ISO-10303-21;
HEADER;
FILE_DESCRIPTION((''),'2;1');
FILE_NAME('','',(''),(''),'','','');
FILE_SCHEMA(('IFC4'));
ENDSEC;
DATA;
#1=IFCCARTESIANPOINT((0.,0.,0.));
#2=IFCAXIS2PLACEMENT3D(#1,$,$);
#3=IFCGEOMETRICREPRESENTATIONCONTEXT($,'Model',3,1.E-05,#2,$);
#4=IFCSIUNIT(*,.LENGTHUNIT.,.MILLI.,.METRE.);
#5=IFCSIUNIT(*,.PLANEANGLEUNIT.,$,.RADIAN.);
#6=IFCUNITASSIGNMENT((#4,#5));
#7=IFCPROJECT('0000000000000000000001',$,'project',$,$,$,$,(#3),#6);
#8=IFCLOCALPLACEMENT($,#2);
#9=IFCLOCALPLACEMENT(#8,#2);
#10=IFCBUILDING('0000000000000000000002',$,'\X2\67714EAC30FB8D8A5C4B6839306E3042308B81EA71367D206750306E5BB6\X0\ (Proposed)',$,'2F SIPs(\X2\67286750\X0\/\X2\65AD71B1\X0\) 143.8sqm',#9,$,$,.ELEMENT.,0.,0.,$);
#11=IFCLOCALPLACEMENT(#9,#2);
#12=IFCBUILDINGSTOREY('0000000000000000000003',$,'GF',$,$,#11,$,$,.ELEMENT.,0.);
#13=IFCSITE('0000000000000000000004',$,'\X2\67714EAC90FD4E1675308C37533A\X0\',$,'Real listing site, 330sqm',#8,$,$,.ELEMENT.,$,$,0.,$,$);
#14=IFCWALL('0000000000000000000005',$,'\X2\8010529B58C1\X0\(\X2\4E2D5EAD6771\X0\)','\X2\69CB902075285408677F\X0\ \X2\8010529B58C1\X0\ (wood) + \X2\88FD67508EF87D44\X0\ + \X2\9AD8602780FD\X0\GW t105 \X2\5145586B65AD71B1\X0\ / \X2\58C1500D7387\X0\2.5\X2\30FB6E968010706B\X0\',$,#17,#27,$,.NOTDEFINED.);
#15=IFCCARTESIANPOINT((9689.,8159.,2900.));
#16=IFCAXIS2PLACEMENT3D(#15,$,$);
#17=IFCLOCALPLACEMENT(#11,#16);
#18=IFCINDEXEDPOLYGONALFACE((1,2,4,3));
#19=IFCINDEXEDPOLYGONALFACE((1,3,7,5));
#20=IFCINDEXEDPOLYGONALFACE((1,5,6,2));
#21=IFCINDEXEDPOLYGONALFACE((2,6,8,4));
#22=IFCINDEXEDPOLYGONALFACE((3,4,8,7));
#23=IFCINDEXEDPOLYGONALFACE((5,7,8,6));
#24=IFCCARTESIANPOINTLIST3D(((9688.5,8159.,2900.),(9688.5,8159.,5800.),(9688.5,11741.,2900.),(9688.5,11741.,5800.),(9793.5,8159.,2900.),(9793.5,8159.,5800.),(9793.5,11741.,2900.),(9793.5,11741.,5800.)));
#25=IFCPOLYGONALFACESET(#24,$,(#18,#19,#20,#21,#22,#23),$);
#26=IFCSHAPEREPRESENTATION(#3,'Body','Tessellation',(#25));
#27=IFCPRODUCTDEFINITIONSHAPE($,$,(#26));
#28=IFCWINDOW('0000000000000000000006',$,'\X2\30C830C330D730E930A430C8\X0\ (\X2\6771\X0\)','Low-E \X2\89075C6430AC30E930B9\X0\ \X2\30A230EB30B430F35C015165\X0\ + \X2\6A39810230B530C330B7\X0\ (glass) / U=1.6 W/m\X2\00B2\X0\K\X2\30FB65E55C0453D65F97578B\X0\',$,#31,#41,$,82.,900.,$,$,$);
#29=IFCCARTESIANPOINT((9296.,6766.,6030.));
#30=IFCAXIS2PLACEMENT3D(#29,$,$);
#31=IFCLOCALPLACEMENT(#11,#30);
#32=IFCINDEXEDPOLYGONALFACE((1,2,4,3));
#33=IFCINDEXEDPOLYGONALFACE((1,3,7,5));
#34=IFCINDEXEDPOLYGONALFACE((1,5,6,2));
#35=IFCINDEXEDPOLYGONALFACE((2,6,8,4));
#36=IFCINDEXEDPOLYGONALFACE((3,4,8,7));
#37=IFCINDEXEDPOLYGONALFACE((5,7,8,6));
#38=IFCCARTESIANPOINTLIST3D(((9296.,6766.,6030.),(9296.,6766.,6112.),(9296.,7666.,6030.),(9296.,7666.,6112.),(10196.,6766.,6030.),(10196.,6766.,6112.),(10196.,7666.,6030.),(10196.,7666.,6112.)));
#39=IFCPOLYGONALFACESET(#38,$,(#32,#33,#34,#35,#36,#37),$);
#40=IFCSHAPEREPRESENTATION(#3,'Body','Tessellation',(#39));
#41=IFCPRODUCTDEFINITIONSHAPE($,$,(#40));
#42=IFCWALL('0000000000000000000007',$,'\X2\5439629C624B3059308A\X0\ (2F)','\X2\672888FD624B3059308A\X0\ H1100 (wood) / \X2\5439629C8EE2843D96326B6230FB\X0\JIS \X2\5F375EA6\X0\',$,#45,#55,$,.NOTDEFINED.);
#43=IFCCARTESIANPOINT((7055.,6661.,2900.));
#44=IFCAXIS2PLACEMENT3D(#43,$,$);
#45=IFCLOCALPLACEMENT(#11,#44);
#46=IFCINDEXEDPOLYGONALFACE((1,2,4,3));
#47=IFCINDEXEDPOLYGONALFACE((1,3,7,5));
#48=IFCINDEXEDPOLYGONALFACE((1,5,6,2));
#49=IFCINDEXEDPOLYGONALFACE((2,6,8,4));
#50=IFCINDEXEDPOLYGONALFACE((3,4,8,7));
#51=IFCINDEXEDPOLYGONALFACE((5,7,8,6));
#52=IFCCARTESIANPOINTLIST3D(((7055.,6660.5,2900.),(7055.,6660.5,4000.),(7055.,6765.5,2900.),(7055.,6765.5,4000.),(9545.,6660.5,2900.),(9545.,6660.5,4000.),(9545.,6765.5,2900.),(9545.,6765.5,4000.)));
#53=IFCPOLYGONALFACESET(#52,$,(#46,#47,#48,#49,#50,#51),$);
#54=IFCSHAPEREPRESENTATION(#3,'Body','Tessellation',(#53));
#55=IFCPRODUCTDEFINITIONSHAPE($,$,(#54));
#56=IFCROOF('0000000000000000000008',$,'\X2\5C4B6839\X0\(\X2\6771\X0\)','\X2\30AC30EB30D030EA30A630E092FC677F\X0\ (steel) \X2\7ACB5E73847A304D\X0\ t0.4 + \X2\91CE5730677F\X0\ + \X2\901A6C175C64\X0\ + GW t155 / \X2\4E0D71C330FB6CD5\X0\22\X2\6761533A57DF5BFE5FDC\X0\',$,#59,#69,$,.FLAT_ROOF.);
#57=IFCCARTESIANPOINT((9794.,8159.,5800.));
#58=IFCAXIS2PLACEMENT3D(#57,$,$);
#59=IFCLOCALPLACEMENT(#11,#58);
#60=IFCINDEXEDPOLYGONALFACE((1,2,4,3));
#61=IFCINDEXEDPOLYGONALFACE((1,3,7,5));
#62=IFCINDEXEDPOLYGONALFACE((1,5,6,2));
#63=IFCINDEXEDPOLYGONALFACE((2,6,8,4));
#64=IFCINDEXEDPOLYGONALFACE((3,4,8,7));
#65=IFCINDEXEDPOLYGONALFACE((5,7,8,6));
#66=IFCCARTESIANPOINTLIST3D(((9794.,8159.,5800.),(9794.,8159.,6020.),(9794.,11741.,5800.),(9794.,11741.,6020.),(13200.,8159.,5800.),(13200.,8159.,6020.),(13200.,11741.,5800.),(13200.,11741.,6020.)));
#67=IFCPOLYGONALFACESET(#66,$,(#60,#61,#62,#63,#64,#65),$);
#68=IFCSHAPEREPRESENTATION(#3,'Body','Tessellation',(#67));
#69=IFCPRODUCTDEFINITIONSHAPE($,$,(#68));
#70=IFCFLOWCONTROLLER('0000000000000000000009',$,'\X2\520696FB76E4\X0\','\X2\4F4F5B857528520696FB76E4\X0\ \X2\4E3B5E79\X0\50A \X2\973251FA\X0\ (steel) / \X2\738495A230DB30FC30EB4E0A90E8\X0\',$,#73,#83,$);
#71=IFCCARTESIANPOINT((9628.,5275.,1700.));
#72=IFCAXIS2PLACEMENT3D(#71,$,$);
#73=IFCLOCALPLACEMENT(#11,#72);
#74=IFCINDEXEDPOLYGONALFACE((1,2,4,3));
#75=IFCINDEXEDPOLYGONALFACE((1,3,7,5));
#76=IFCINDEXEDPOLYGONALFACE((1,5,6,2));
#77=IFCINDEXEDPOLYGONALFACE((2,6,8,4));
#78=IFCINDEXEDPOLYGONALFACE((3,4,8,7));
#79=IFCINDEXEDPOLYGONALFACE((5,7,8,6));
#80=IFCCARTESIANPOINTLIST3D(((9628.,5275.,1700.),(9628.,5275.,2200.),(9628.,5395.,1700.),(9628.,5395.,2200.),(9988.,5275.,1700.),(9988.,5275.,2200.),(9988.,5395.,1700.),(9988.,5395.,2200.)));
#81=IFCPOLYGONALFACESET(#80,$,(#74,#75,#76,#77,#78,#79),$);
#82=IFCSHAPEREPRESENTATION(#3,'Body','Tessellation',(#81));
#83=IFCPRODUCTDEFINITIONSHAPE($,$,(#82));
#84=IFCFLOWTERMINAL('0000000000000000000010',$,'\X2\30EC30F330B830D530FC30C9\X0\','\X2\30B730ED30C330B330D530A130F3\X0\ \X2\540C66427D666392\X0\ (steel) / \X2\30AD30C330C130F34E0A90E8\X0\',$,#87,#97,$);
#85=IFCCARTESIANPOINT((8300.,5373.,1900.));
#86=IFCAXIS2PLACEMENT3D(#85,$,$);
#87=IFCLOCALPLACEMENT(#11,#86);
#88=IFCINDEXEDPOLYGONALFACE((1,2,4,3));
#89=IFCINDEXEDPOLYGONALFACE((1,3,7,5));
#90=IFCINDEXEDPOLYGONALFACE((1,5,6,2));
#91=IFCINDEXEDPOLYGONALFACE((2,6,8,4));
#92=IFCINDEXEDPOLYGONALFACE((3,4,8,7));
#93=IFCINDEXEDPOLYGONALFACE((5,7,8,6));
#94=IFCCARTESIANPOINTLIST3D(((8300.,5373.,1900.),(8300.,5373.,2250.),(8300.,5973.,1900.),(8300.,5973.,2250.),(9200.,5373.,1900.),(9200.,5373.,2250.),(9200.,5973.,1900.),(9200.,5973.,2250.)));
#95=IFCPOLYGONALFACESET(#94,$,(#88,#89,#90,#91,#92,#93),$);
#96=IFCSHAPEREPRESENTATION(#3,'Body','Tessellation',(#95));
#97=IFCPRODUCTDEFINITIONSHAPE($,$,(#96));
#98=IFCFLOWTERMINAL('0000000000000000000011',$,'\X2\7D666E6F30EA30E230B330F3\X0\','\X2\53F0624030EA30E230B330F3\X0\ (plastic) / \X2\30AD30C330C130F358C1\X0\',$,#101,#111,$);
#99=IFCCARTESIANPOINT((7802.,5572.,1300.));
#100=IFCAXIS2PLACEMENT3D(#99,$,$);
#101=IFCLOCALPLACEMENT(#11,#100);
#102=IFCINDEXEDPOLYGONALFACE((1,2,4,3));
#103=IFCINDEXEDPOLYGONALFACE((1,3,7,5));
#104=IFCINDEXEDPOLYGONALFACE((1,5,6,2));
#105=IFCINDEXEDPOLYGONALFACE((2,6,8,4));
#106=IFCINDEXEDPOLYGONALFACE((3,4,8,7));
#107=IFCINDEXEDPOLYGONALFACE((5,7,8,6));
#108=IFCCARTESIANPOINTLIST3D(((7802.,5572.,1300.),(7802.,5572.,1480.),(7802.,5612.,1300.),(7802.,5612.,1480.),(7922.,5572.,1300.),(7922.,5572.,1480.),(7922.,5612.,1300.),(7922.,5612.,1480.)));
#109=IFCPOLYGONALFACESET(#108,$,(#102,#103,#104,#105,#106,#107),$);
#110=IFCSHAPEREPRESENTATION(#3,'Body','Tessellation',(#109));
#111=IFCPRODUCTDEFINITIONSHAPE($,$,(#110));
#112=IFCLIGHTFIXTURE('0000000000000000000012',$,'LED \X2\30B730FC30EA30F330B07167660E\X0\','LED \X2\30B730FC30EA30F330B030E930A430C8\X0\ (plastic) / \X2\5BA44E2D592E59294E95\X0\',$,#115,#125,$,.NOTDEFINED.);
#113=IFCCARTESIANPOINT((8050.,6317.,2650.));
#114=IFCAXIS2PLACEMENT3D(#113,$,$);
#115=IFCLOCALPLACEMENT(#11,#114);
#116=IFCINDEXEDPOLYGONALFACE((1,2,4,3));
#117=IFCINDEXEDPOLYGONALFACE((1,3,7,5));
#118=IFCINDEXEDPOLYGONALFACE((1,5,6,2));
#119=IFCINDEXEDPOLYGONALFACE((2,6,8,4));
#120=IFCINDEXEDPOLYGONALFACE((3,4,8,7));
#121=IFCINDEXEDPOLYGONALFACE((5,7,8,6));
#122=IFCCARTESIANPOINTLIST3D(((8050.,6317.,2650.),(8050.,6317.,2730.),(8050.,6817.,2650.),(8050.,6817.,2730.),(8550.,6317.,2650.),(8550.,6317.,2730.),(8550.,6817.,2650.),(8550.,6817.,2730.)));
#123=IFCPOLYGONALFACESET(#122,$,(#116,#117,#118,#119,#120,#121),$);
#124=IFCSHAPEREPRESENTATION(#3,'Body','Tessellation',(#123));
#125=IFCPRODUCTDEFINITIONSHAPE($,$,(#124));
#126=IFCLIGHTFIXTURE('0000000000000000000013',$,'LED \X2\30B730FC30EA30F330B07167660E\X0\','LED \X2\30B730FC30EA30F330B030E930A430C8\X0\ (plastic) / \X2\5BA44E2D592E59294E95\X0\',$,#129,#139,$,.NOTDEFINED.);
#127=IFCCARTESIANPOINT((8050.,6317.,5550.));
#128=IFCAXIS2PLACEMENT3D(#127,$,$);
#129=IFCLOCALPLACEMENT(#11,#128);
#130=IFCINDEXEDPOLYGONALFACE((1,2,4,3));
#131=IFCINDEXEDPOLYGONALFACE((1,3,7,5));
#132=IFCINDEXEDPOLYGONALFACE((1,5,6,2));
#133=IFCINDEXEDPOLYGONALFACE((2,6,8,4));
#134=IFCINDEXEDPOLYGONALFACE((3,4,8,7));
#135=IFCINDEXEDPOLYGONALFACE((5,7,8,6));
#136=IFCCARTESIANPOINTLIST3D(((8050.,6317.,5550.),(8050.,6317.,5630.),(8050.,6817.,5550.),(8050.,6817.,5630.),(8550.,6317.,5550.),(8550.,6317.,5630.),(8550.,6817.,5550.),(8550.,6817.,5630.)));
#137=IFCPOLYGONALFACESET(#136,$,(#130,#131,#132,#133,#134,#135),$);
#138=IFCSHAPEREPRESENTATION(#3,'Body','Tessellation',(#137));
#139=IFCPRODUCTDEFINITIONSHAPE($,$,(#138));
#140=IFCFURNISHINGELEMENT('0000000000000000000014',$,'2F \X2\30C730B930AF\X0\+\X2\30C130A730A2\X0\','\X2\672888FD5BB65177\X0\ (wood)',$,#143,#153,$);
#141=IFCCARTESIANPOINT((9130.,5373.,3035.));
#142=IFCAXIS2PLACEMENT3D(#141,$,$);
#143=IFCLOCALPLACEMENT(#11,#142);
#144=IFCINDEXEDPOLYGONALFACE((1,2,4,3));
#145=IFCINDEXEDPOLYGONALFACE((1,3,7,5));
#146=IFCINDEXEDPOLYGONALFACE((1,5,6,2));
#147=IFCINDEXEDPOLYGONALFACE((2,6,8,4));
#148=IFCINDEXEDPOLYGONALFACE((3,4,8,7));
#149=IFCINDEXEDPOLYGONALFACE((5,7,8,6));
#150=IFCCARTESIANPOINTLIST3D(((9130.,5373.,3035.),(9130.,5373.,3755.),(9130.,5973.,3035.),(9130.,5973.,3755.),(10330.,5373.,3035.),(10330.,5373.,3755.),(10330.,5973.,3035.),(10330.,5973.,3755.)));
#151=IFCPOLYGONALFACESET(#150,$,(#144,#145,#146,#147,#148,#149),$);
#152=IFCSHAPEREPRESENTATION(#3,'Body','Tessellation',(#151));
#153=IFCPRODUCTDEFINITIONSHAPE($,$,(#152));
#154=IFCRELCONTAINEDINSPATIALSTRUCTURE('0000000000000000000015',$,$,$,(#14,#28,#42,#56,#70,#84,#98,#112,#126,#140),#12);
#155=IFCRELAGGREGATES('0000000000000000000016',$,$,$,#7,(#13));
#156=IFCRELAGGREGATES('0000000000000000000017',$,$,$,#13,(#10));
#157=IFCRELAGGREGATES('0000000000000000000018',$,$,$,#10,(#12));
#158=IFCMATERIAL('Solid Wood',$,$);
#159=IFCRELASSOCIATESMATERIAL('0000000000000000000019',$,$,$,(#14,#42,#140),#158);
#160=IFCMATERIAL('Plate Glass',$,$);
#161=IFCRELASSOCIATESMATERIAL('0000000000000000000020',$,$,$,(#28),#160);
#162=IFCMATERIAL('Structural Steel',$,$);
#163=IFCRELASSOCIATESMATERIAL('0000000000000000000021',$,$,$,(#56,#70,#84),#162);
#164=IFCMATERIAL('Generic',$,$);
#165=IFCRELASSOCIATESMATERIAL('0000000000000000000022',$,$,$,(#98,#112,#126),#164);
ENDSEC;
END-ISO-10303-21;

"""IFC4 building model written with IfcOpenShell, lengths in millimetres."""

from ifc_helpers import new_model, si_unit, frame, frame_2d, origin, place, context, project, spatial, rectangle, extrude, material, element, save


model = new_model("IFC4")

# Units and contexts
model_context = context("Model", 3, precision=1e-05, world=origin())
ifc_project = project(units=[si_unit("LENGTHUNIT", "METRE", prefix="MILLI"), si_unit("PLANEANGLEUNIT", "RADIAN")], contexts=[model_context])

# Site, building, storey
site_placement = place(None, origin())
site = spatial("IfcSite", under=ifc_project, at=site_placement, Name="東京都世田谷区", ObjectType="Real listing site, 330sqm", CompositionType="ELEMENT", RefElevation=0.0)
building_placement = place(site_placement, origin())
building = spatial("IfcBuilding", under=site, at=building_placement, Name="東京・越屋根のある自然素材の家 (Proposed)", ObjectType="2F SIPs(木材/断熱) 143.8sqm", CompositionType="ELEMENT", ElevationOfRefHeight=0.0, ElevationOfTerrain=0.0)
storey_placement = place(building_placement, origin())
storey = spatial("IfcBuildingStorey", under=building, at=storey_placement, Name="GF", CompositionType="ELEMENT", Elevation=0.0)

# Shared definitions
ifc_material_1 = material(Name="Solid Wood")

# Shared definitions
ifc_material_2 = material(Name="Plate Glass")

# Wall
wall_1_placement = place(storey_placement, frame((9689.0, 8159.0, 2900.0)))
element("IfcWall", 1, at=wall_1_placement, inside=storey, material=ifc_material_1, Name="耐力壁(中庭東)", Description="構造用合板 耐力壁 (wood) + 製材軸組 + 高性能GW t105 充填断熱 / 壁倍率2.5・準耐火", PredefinedType="NOTDEFINED", context=model_context, shape_type="SweptSolid", body=[
    extrude(rectangle(XDim=105.0, YDim=3582.0, at=frame_2d((52.0, 1791.0))), frame((9689.0, 8159.0, 2900.0)), (0.0, 0.0, 1.0), 2900.0),
])

# Window
window_1_placement = place(storey_placement, frame((9296.0, 6766.0, 6030.0)))
element("IfcWindow", 2, at=window_1_placement, inside=storey, material=ifc_material_2, Name="トップライト (東)", Description="Low-E 複層ガラス アルゴン封入 + 樹脂サッシ (glass) / U=1.6 W/m²K・日射取得型", OverallHeight=82.0, OverallWidth=900.0, context=model_context, shape_type="SweptSolid", body=[
    extrude(rectangle(XDim=900.0, YDim=900.0, at=frame_2d((450.0, 450.0))), frame((9296.0, 6766.0, 6030.0)), (0.0, 0.0, 1.0), 82.0),
])

# Wall
wall_2_placement = place(storey_placement, frame((7055.0, 6661.0, 2900.0)))
element("IfcWall", 3, at=wall_2_placement, inside=storey, material=ifc_material_1, Name="吹抜手すり (2F)", Description="木製手すり H1100 (wood) / 吹抜転落防止・JIS 強度", PredefinedType="NOTDEFINED", context=model_context, shape_type="SweptSolid", body=[
    extrude(rectangle(XDim=2490.0, YDim=105.0, at=frame_2d((1245.0, 52.0))), frame((7055.0, 6661.0, 2900.0)), (0.0, 0.0, 1.0), 1100.0),
])

# Roof
ifc_material_3 = material(Name="Structural Steel")
for number, where, name in (
    (4, (9794.0, 8159.0, 5800.0), "屋根(東)"),
):
    element("IfcRoof", number, at=place(storey_placement, frame(where)), inside=storey, material=ifc_material_3, Name=name, Description="ガルバリウム鋼板 (steel) 立平葺き t0.4 + 野地板 + 通気層 + GW t155 / 不燃・法22条区域対応", PredefinedType="FLAT_ROOF", context=model_context, shape_type="SweptSolid", body=[
        extrude(rectangle(XDim=3406.0, YDim=3582.0, at=frame_2d((1703.0, 1791.0))), frame((9794.0, 8159.0, 5800.0)), (0.0, 0.0, 1.0), 220.0),
    ])

# Flow controller
flow_controller_placement = place(storey_placement, frame((9628.0, 5275.0, 1700.0)))
element("IfcFlowController", 5, at=flow_controller_placement, inside=storey, material=ifc_material_3, Name="分電盤", Description="住宅用分電盤 主幹50A 露出 (steel) / 玄関ホール上部", context=model_context, shape_type="SweptSolid", body=[
    extrude(rectangle(XDim=360.0, YDim=120.0, at=frame_2d((180.0, 60.0))), frame((9628.0, 5275.0, 1700.0)), (0.0, 0.0, 1.0), 500.0),
])

# Flow terminals
flow_terminal_1_placement = place(storey_placement, frame((8300.0, 5373.0, 1900.0)))
element("IfcFlowTerminal", 6, at=flow_terminal_1_placement, inside=storey, material=ifc_material_3, Name="レンジフード", Description="シロッコファン 同時給排 (steel) / キッチン上部", context=model_context, shape_type="SweptSolid", body=[
    extrude(rectangle(XDim=900.0, YDim=600.0, at=frame_2d((450.0, 300.0))), frame((8300.0, 5373.0, 1900.0)), (0.0, 0.0, 1.0), 350.0),
])
ifc_material_4 = material(Name="Generic")
flow_terminal_2_placement = place(storey_placement, frame((7802.0, 5572.0, 1300.0)))
element("IfcFlowTerminal", 7, at=flow_terminal_2_placement, inside=storey, material=ifc_material_4, Name="給湯リモコン", Description="台所リモコン (plastic) / キッチン壁", context=model_context, shape_type="SweptSolid", body=[
    extrude(rectangle(XDim=120.0, YDim=40.0, at=frame_2d((60.0, 20.0))), frame((7802.0, 5572.0, 1300.0)), (0.0, 0.0, 1.0), 180.0),
])

# Light fixtures
light_fixture_1_placement = place(storey_placement, frame((8050.0, 6317.0, 2650.0)))
element("IfcLightFixture", 8, at=light_fixture_1_placement, inside=storey, material=ifc_material_4, Name="LED シーリング照明", Description="LED シーリングライト (plastic) / 室中央天井", PredefinedType="NOTDEFINED", context=model_context, shape_type="SweptSolid", body=[
    extrude(rectangle(XDim=500.0, YDim=500.0, at=frame_2d((250.0, 250.0))), frame((8050.0, 6317.0, 2650.0)), (0.0, 0.0, 1.0), 80.0),
])
light_fixture_2_placement = place(storey_placement, frame((8050.0, 6317.0, 5550.0)))
element("IfcLightFixture", 9, at=light_fixture_2_placement, inside=storey, material=ifc_material_4, Name="LED シーリング照明", Description="LED シーリングライト (plastic) / 室中央天井", PredefinedType="NOTDEFINED", context=model_context, shape_type="SweptSolid", body=[
    extrude(rectangle(XDim=500.0, YDim=500.0, at=frame_2d((250.0, 250.0))), frame((8050.0, 6317.0, 5550.0)), (0.0, 0.0, 1.0), 80.0),
])

# Furnishing element
furnishing_placement = place(storey_placement, frame((9130.0, 5373.0, 3035.0)))
element("IfcFurnishingElement", 10, at=furnishing_placement, inside=storey, material=ifc_material_1, Name="2F デスク+チェア", Description="木製家具 (wood)", context=model_context, shape_type="SweptSolid", body=[
    extrude(rectangle(XDim=1200.0, YDim=600.0, at=frame_2d((600.0, 300.0))), frame((9130.0, 5373.0, 3035.0)), (0.0, 0.0, 1.0), 720.0),
])

save(model, "model.ifc")
